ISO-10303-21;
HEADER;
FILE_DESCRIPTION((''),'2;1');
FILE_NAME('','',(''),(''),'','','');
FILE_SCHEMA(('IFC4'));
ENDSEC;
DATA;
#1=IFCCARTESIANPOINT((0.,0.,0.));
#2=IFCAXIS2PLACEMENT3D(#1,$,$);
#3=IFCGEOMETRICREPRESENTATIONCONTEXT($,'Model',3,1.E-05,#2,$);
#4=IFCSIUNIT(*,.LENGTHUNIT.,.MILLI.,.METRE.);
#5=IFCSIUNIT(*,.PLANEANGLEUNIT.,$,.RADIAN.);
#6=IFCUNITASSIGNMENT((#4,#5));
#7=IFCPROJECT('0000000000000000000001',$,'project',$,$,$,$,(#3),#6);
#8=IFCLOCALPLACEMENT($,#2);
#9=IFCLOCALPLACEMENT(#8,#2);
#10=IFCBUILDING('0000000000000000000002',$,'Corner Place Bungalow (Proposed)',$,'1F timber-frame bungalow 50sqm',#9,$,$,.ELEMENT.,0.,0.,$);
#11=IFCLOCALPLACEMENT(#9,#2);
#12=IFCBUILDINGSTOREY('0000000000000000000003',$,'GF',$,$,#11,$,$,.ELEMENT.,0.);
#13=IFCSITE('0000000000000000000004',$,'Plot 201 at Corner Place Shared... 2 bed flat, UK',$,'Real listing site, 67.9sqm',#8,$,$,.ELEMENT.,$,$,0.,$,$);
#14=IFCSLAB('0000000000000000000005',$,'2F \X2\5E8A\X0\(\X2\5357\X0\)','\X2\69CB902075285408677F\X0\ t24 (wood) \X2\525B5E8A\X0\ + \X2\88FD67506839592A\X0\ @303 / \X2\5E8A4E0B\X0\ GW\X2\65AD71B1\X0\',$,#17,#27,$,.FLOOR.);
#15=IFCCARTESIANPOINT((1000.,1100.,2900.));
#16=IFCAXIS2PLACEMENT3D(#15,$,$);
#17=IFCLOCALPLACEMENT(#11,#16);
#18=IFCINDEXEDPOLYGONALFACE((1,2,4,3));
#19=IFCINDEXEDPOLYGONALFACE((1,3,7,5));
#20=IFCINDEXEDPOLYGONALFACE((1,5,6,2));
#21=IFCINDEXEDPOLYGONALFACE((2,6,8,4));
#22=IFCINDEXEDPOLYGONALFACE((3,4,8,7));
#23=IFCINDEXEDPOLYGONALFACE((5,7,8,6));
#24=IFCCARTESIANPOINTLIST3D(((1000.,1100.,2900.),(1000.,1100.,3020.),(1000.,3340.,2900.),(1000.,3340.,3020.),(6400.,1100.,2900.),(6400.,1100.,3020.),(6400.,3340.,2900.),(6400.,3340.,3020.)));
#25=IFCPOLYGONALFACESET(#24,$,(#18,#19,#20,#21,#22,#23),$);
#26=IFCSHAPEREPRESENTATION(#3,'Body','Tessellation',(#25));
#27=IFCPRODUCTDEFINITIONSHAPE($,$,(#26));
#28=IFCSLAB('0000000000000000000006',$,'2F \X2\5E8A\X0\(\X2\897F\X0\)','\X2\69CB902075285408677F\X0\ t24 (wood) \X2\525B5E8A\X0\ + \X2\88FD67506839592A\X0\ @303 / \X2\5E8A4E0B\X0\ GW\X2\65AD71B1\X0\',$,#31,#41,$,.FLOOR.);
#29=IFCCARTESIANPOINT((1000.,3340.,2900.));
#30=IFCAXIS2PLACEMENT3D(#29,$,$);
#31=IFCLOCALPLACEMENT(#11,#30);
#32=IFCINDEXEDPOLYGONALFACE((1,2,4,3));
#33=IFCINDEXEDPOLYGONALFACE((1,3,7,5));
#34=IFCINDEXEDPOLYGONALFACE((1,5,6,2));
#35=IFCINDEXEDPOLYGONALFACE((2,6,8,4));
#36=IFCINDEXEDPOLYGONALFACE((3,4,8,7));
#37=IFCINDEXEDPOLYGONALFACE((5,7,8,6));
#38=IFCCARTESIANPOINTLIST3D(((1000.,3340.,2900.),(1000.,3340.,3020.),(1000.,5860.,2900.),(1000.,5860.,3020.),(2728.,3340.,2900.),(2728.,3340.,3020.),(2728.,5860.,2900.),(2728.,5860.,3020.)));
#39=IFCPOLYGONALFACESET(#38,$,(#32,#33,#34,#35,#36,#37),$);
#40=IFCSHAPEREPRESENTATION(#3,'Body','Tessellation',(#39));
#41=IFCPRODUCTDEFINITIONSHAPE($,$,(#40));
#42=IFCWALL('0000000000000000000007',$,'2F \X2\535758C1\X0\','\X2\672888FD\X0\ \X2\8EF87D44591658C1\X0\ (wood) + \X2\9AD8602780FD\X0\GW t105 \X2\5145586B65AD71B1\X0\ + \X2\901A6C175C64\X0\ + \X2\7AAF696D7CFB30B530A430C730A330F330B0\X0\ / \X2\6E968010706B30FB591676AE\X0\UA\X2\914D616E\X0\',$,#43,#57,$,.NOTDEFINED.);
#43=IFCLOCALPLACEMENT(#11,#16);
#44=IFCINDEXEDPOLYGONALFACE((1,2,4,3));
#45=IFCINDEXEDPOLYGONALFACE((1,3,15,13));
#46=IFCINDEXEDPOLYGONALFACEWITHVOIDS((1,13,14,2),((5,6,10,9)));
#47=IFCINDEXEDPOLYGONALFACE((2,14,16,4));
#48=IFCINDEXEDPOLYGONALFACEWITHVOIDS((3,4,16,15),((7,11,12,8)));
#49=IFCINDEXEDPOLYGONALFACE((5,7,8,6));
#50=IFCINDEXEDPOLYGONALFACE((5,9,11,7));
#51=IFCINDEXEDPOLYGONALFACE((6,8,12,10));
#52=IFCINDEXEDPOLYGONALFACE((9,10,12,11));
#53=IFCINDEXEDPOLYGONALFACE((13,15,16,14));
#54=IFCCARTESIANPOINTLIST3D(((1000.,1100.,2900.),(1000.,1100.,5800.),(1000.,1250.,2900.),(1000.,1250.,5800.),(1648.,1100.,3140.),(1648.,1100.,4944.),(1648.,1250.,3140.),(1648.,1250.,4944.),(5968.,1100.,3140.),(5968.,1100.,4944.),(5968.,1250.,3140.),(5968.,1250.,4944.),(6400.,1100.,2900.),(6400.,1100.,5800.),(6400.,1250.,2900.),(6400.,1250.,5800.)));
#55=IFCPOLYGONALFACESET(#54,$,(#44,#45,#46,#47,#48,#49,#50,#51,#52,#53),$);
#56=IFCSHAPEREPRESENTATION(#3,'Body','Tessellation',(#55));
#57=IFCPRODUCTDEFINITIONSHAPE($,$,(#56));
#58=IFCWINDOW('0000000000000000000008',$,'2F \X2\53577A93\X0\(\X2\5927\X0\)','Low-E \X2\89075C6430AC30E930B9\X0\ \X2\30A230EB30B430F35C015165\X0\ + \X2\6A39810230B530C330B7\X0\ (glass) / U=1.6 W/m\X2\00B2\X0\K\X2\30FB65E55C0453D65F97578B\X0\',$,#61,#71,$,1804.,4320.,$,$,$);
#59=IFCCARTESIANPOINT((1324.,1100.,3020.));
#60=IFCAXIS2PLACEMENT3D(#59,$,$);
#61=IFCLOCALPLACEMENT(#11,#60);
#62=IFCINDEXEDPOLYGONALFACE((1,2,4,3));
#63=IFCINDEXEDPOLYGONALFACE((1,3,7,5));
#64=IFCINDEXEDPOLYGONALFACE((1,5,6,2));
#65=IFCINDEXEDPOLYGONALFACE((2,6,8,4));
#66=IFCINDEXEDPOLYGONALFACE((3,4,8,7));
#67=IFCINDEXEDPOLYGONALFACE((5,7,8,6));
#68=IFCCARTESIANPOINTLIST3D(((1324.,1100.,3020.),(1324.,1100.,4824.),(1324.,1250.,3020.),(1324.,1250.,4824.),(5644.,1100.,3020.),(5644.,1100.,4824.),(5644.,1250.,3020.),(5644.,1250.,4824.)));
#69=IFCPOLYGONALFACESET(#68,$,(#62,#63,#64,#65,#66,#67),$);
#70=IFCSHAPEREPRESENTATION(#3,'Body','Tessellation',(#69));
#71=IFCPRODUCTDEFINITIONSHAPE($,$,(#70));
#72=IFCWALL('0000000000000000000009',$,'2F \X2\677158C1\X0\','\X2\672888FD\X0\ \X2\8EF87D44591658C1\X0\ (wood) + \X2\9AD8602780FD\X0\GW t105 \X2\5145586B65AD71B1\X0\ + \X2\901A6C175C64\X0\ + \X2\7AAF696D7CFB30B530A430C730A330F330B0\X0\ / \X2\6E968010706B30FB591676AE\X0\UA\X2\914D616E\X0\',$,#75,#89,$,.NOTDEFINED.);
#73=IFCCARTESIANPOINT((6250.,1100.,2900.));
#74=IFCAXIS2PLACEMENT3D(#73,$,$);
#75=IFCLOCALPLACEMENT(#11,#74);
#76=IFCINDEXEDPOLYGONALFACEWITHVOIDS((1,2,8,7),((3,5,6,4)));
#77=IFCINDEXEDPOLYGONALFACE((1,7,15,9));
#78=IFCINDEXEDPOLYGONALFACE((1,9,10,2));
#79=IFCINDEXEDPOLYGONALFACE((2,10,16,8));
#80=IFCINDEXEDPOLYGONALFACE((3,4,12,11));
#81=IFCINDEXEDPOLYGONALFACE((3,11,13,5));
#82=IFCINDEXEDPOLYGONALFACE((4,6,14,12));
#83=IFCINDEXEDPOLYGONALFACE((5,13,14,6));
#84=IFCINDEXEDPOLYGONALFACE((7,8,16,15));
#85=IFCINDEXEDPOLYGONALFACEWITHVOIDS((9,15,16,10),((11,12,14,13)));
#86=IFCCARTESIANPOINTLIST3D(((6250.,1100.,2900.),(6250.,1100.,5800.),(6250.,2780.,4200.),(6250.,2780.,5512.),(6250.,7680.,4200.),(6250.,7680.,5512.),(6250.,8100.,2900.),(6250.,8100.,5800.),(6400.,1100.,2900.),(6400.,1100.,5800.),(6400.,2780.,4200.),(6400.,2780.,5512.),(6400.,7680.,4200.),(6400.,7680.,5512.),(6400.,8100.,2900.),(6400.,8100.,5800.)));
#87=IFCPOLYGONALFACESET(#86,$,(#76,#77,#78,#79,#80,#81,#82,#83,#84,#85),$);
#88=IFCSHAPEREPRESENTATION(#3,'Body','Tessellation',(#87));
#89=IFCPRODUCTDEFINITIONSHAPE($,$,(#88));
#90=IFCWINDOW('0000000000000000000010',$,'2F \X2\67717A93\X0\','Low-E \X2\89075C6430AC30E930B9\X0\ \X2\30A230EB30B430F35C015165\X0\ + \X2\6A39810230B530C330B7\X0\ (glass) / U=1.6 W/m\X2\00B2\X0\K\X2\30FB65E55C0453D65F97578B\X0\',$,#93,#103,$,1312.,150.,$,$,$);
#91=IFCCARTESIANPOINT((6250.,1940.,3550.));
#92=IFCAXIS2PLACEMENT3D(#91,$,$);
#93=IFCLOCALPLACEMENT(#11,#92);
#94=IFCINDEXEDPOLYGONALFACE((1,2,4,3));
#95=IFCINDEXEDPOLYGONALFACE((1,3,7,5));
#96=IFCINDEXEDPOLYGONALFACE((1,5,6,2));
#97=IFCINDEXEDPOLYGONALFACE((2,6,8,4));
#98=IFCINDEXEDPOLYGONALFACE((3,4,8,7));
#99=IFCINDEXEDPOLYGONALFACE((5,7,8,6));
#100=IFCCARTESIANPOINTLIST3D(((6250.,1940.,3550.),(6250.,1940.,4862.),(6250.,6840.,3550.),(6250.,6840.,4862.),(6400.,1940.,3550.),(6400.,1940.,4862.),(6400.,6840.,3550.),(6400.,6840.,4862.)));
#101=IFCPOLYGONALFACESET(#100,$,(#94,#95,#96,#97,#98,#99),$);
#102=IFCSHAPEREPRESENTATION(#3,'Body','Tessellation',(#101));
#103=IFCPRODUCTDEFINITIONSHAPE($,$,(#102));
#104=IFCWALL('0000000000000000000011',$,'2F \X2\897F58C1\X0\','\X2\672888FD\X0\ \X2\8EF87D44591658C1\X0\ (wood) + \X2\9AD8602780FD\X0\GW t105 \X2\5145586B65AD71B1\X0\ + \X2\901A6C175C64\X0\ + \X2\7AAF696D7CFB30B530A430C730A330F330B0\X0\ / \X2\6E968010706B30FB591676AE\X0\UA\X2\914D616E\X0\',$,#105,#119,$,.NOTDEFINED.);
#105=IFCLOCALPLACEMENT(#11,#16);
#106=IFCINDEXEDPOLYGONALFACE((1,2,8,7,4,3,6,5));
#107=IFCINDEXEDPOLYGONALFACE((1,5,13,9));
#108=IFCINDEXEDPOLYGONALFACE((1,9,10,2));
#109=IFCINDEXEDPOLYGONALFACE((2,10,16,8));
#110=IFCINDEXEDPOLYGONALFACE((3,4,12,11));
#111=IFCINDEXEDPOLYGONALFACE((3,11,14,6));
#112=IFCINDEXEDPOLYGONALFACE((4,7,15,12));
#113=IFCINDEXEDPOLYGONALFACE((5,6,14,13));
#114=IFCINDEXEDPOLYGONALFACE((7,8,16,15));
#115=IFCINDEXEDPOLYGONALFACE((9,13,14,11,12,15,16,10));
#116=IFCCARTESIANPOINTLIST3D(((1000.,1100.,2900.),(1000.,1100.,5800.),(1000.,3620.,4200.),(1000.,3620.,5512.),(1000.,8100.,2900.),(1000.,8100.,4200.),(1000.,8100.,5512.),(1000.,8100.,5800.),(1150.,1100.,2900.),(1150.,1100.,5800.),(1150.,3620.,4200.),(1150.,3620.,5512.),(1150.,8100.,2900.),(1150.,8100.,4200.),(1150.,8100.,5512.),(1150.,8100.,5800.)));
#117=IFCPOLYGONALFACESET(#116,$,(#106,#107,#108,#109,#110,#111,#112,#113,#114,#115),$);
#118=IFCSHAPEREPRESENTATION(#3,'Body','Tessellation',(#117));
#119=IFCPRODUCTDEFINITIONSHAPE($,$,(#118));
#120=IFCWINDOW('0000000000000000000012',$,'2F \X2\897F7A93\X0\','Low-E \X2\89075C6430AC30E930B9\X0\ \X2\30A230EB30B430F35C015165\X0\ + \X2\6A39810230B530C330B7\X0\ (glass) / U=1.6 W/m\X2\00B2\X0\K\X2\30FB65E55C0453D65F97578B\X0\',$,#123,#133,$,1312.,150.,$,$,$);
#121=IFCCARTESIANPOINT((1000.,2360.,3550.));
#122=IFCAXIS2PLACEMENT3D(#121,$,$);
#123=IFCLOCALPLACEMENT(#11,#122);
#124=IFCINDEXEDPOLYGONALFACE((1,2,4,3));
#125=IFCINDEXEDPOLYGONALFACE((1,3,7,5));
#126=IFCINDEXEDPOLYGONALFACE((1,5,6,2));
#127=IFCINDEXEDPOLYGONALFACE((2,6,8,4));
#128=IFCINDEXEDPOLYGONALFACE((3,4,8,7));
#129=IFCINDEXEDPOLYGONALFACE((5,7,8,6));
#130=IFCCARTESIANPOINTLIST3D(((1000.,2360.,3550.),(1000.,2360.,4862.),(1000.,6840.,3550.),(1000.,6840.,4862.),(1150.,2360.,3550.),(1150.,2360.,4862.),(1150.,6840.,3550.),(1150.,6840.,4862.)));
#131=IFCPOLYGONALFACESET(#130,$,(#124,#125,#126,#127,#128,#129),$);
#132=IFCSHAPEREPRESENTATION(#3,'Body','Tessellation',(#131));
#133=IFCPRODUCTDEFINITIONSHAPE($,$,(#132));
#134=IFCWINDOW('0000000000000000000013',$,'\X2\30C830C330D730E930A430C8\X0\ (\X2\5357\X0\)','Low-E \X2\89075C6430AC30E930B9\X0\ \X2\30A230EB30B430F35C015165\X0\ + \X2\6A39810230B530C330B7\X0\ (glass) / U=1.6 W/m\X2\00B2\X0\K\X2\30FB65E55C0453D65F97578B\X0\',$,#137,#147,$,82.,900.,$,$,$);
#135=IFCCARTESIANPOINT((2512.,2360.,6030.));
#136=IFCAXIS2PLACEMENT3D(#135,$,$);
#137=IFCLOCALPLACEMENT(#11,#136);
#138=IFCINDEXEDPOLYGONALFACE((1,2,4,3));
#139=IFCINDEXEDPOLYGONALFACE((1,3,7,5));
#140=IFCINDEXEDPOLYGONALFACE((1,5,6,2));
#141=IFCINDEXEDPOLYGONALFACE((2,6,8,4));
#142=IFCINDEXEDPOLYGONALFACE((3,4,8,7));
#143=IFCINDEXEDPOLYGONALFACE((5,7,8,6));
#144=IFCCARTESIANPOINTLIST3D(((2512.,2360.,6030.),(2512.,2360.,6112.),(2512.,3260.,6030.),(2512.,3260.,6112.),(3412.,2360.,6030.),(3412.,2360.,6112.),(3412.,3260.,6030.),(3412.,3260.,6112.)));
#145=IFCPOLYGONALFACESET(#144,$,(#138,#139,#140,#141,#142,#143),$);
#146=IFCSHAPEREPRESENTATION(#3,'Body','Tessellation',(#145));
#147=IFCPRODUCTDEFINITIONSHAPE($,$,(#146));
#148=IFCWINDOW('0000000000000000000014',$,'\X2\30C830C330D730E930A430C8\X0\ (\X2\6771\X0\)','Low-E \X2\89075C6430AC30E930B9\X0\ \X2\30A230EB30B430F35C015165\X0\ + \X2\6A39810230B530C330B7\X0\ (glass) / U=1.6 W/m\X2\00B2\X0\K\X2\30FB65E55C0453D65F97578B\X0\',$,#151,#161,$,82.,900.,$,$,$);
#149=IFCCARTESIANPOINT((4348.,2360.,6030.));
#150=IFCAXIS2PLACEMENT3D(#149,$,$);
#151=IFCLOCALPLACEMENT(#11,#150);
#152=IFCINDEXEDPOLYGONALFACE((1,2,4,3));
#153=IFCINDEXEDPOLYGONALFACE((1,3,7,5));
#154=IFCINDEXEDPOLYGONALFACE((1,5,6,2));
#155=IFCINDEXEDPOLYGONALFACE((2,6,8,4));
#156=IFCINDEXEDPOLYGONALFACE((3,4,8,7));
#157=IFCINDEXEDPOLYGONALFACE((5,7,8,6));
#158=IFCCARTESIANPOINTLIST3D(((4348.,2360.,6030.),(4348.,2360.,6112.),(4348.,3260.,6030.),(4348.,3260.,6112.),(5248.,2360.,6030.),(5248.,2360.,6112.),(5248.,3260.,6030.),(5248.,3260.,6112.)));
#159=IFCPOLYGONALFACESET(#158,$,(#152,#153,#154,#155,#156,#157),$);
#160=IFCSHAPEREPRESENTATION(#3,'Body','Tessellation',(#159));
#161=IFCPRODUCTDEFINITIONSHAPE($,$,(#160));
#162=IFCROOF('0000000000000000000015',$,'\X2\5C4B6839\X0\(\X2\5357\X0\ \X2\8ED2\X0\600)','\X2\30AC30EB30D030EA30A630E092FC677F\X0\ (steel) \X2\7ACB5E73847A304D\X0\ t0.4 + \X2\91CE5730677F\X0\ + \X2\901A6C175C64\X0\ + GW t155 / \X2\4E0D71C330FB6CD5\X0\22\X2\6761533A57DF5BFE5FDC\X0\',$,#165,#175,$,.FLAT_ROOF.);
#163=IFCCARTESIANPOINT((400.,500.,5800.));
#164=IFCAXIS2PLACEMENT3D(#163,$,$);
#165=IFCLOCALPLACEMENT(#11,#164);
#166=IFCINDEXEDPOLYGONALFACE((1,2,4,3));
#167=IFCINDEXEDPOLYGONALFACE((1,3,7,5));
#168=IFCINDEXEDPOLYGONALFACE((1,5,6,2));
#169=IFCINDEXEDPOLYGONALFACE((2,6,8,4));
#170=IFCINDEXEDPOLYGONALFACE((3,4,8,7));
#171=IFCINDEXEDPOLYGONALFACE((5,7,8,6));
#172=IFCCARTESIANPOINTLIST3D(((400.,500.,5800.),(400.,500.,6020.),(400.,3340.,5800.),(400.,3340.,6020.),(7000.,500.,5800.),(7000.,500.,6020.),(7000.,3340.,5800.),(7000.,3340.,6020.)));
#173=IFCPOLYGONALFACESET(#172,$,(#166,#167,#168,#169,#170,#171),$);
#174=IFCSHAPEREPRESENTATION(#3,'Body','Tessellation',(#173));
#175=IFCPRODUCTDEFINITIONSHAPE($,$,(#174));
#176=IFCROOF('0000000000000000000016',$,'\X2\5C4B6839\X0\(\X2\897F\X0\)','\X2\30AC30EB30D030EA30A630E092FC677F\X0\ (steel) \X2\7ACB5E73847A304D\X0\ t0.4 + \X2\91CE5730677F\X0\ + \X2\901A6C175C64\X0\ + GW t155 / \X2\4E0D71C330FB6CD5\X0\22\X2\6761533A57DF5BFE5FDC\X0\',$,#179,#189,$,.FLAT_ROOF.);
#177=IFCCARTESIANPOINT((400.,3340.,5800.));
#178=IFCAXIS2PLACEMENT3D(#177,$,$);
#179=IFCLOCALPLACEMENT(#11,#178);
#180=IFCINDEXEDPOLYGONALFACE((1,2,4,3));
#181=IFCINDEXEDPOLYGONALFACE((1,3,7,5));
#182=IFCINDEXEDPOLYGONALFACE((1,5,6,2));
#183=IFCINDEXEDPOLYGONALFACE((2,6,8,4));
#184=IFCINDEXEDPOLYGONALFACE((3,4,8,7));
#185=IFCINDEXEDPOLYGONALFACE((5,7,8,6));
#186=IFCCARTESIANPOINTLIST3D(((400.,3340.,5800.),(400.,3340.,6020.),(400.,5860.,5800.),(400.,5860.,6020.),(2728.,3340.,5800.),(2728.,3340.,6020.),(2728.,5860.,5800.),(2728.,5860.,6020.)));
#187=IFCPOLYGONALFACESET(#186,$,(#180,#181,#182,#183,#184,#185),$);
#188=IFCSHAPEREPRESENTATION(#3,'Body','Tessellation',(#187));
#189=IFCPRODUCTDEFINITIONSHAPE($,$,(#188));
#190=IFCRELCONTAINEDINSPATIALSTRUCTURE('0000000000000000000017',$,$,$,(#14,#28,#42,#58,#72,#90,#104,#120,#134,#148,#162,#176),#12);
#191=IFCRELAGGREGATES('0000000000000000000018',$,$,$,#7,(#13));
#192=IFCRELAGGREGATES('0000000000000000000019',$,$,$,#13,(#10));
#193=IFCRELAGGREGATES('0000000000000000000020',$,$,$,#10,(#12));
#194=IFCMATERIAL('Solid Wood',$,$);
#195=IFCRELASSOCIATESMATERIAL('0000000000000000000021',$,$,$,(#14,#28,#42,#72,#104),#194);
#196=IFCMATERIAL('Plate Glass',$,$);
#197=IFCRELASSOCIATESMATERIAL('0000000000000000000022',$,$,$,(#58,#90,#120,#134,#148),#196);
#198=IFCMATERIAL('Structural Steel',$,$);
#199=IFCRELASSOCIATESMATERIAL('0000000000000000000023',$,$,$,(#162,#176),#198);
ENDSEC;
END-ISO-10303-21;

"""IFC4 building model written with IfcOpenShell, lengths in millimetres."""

from ifc_helpers import new_model, si_unit, frame, frame_2d, origin, place, context, project, spatial, rectangle, extrude, material, element, fill, save


model = new_model("IFC4")

# Units and contexts
model_context = context("Model", 3, precision=1e-05, world=origin())
ifc_project = project(units=[si_unit("LENGTHUNIT", "METRE", prefix="MILLI"), si_unit("PLANEANGLEUNIT", "RADIAN")], contexts=[model_context])

# Site, building, storey
site_placement = place(None, origin())
site = spatial("IfcSite", under=ifc_project, at=site_placement, Name="Plot 201 at Corner Place Shared... 2 bed flat, UK", ObjectType="Real listing site, 67.9sqm", CompositionType="ELEMENT", RefElevation=0.0)
building_placement = place(site_placement, origin())
building = spatial("IfcBuilding", under=site, at=building_placement, Name="Corner Place Bungalow (Proposed)", ObjectType="1F timber-frame bungalow 50sqm", CompositionType="ELEMENT", ElevationOfRefHeight=0.0, ElevationOfTerrain=0.0)
storey_placement = place(building_placement, origin())
storey = spatial("IfcBuildingStorey", under=building, at=storey_placement, Name="GF", CompositionType="ELEMENT", Elevation=0.0)

# Slabs
ifc_material_1 = material(Name="Solid Wood")
slab_1_placement = place(storey_placement, frame((1000.0, 1100.0, 2900.0)))
element("IfcSlab", 1, at=slab_1_placement, inside=storey, material=ifc_material_1, Name="2F 床(南)", Description="構造用合板 t24 (wood) 剛床 + 製材根太 @303 / 床下 GW断熱", PredefinedType="FLOOR", context=model_context, shape_type="SweptSolid", body=[
    extrude(rectangle(XDim=5400.0, YDim=2240.0, at=frame_2d((2700.0, 1120.0))), frame((1000.0, 1100.0, 2900.0)), (0.0, 0.0, 1.0), 120.0),
])
slab_2_placement = place(storey_placement, frame((1000.0, 3340.0, 2900.0)))
element("IfcSlab", 2, at=slab_2_placement, inside=storey, material=ifc_material_1, Name="2F 床(西)", Description="構造用合板 t24 (wood) 剛床 + 製材根太 @303 / 床下 GW断熱", PredefinedType="FLOOR", context=model_context, shape_type="SweptSolid", body=[
    extrude(rectangle(XDim=1728.0, YDim=2520.0, at=frame_2d((864.0, 1260.0))), frame((1000.0, 3340.0, 2900.0)), (0.0, 0.0, 1.0), 120.0),
])

# Walls, openings, windows
wall_1_placement = place(storey_placement, frame((1000.0, 1100.0, 2900.0)))
wall_1 = element("IfcWall", 3, at=wall_1_placement, inside=storey, material=ifc_material_1, Name="2F 南壁", Description="木製 軸組外壁 (wood) + 高性能GW t105 充填断熱 + 通気層 + 窯業系サイディング / 準耐火・外皮UA配慮", PredefinedType="NOTDEFINED", context=model_context, shape_type="SweptSolid", body=[
    extrude(rectangle(XDim=5400.0, YDim=150.0, at=frame_2d((2700.0, 75.0))), frame((1000.0, 1100.0, 2900.0)), (0.0, 0.0, 1.0), 2900.0),
])
opening_1_placement = place(storey_placement, frame((1324.0, 1100.0, 3020.0)))
opening_1 = element("IfcOpeningElement", 4, at=opening_1_placement, cuts=wall_1, PredefinedType="NOTDEFINED", context=model_context, shape_type="SweptSolid", body=[
    extrude(rectangle(XDim=4320.0, YDim=150.0, at=frame_2d((2160.0, 75.0))), frame((1324.0, 1100.0, 3020.0)), (0.0, 0.0, 1.0), 1804.0),
])
ifc_material_2 = material(Name="Plate Glass")
window_1_placement = place(storey_placement, frame((1324.0, 1100.0, 3020.0)))
window_1 = element("IfcWindow", 5, at=window_1_placement, inside=storey, material=ifc_material_2, Name="2F 南窓(大)", Description="Low-E 複層ガラス アルゴン封入 + 樹脂サッシ (glass) / U=1.6 W/m²K・日射取得型", OverallHeight=1804.0, OverallWidth=4320.0, context=model_context, shape_type="SweptSolid", body=[
    extrude(rectangle(XDim=4320.0, YDim=150.0, at=frame_2d((2160.0, 75.0))), frame((1324.0, 1100.0, 3020.0)), (0.0, 0.0, 1.0), 1804.0),
])
fill(opening_1, window_1)
wall_2_placement = place(storey_placement, frame((6250.0, 1100.0, 2900.0)))
wall_2 = element("IfcWall", 6, at=wall_2_placement, inside=storey, material=ifc_material_1, Name="2F 東壁", Description="木製 軸組外壁 (wood) + 高性能GW t105 充填断熱 + 通気層 + 窯業系サイディング / 準耐火・外皮UA配慮", PredefinedType="NOTDEFINED", context=model_context, shape_type="SweptSolid", body=[
    extrude(rectangle(XDim=150.0, YDim=7000.0, at=frame_2d((75.0, 3500.0))), frame((6250.0, 1100.0, 2900.0)), (0.0, 0.0, 1.0), 2900.0),
])
opening_2_placement = place(storey_placement, frame((6250.0, 1940.0, 3550.0)))
opening_2 = element("IfcOpeningElement", 7, at=opening_2_placement, cuts=wall_2, PredefinedType="NOTDEFINED", context=model_context, shape_type="SweptSolid", body=[
    extrude(rectangle(XDim=150.0, YDim=4900.0, at=frame_2d((75.0, 2450.0))), frame((6250.0, 1940.0, 3550.0)), (0.0, 0.0, 1.0), 1312.0),
])
window_2_placement = place(storey_placement, frame((6250.0, 1940.0, 3550.0)))
window_2 = element("IfcWindow", 8, at=window_2_placement, inside=storey, material=ifc_material_2, Name="2F 東窓", Description="Low-E 複層ガラス アルゴン封入 + 樹脂サッシ (glass) / U=1.6 W/m²K・日射取得型", OverallHeight=1312.0, OverallWidth=150.0, context=model_context, shape_type="SweptSolid", body=[
    extrude(rectangle(XDim=150.0, YDim=4900.0, at=frame_2d((75.0, 2450.0))), frame((6250.0, 1940.0, 3550.0)), (0.0, 0.0, 1.0), 1312.0),
])
fill(opening_2, window_2)
wall_3_placement = place(storey_placement, frame((1000.0, 1100.0, 2900.0)))
wall_3 = element("IfcWall", 9, at=wall_3_placement, inside=storey, material=ifc_material_1, Name="2F 西壁", Description="木製 軸組外壁 (wood) + 高性能GW t105 充填断熱 + 通気層 + 窯業系サイディング / 準耐火・外皮UA配慮", PredefinedType="NOTDEFINED", context=model_context, shape_type="SweptSolid", body=[
    extrude(rectangle(XDim=150.0, YDim=7000.0, at=frame_2d((75.0, 3500.0))), frame((1000.0, 1100.0, 2900.0)), (0.0, 0.0, 1.0), 2900.0),
])
opening_3_placement = place(storey_placement, frame((1000.0, 2360.0, 3550.0)))
opening_3 = element("IfcOpeningElement", 10, at=opening_3_placement, cuts=wall_3, PredefinedType="NOTDEFINED", context=model_context, shape_type="SweptSolid", body=[
    extrude(rectangle(XDim=150.0, YDim=4480.0, at=frame_2d((75.0, 2240.0))), frame((1000.0, 2360.0, 3550.0)), (0.0, 0.0, 1.0), 1312.0),
])
window_3_placement = place(storey_placement, frame((1000.0, 2360.0, 3550.0)))
window_3 = element("IfcWindow", 11, at=window_3_placement, inside=storey, material=ifc_material_2, Name="2F 西窓", Description="Low-E 複層ガラス アルゴン封入 + 樹脂サッシ (glass) / U=1.6 W/m²K・日射取得型", OverallHeight=1312.0, OverallWidth=150.0, context=model_context, shape_type="SweptSolid", body=[
    extrude(rectangle(XDim=150.0, YDim=4480.0, at=frame_2d((75.0, 2240.0))), frame((1000.0, 2360.0, 3550.0)), (0.0, 0.0, 1.0), 1312.0),
])
fill(opening_3, window_3)

# Windows
window_4_placement = place(storey_placement, frame((2512.0, 2360.0, 6030.0)))
element("IfcWindow", 12, at=window_4_placement, inside=storey, material=ifc_material_2, Name="トップライト (南)", Description="Low-E 複層ガラス アルゴン封入 + 樹脂サッシ (glass) / U=1.6 W/m²K・日射取得型", OverallHeight=82.0, OverallWidth=900.0, context=model_context, shape_type="SweptSolid", body=[
    extrude(rectangle(XDim=900.0, YDim=900.0, at=frame_2d((450.0, 450.0))), frame((2512.0, 2360.0, 6030.0)), (0.0, 0.0, 1.0), 82.0),
])
window_5_placement = place(storey_placement, frame((4348.0, 2360.0, 6030.0)))
element("IfcWindow", 13, at=window_5_placement, inside=storey, material=ifc_material_2, Name="トップライト (東)", Description="Low-E 複層ガラス アルゴン封入 + 樹脂サッシ (glass) / U=1.6 W/m²K・日射取得型", OverallHeight=82.0, OverallWidth=900.0, context=model_context, shape_type="SweptSolid", body=[
    extrude(rectangle(XDim=900.0, YDim=900.0, at=frame_2d((450.0, 450.0))), frame((4348.0, 2360.0, 6030.0)), (0.0, 0.0, 1.0), 82.0),
])

# Roofs
ifc_material_3 = material(Name="Structural Steel")
roof_1_placement = place(storey_placement, frame((400.0, 500.0, 5800.0)))
element("IfcRoof", 14, at=roof_1_placement, inside=storey, material=ifc_material_3, Name="屋根(南 軒600)", Description="ガルバリウム鋼板 (steel) 立平葺き t0.4 + 野地板 + 通気層 + GW t155 / 不燃・法22条区域対応", PredefinedType="FLAT_ROOF", context=model_context, shape_type="SweptSolid", body=[
    extrude(rectangle(XDim=6600.0, YDim=2840.0, at=frame_2d((3300.0, 1420.0))), frame((400.0, 500.0, 5800.0)), (0.0, 0.0, 1.0), 220.0),
])
roof_2_placement = place(storey_placement, frame((400.0, 3340.0, 5800.0)))
element("IfcRoof", 15, at=roof_2_placement, inside=storey, material=ifc_material_3, Name="屋根(西)", Description="ガルバリウム鋼板 (steel) 立平葺き t0.4 + 野地板 + 通気層 + GW t155 / 不燃・法22条区域対応", PredefinedType="FLAT_ROOF", context=model_context, shape_type="SweptSolid", body=[
    extrude(rectangle(XDim=2328.0, YDim=2520.0, at=frame_2d((1164.0, 1260.0))), frame((400.0, 3340.0, 5800.0)), (0.0, 0.0, 1.0), 220.0),
])

save(model, "model.ifc")
